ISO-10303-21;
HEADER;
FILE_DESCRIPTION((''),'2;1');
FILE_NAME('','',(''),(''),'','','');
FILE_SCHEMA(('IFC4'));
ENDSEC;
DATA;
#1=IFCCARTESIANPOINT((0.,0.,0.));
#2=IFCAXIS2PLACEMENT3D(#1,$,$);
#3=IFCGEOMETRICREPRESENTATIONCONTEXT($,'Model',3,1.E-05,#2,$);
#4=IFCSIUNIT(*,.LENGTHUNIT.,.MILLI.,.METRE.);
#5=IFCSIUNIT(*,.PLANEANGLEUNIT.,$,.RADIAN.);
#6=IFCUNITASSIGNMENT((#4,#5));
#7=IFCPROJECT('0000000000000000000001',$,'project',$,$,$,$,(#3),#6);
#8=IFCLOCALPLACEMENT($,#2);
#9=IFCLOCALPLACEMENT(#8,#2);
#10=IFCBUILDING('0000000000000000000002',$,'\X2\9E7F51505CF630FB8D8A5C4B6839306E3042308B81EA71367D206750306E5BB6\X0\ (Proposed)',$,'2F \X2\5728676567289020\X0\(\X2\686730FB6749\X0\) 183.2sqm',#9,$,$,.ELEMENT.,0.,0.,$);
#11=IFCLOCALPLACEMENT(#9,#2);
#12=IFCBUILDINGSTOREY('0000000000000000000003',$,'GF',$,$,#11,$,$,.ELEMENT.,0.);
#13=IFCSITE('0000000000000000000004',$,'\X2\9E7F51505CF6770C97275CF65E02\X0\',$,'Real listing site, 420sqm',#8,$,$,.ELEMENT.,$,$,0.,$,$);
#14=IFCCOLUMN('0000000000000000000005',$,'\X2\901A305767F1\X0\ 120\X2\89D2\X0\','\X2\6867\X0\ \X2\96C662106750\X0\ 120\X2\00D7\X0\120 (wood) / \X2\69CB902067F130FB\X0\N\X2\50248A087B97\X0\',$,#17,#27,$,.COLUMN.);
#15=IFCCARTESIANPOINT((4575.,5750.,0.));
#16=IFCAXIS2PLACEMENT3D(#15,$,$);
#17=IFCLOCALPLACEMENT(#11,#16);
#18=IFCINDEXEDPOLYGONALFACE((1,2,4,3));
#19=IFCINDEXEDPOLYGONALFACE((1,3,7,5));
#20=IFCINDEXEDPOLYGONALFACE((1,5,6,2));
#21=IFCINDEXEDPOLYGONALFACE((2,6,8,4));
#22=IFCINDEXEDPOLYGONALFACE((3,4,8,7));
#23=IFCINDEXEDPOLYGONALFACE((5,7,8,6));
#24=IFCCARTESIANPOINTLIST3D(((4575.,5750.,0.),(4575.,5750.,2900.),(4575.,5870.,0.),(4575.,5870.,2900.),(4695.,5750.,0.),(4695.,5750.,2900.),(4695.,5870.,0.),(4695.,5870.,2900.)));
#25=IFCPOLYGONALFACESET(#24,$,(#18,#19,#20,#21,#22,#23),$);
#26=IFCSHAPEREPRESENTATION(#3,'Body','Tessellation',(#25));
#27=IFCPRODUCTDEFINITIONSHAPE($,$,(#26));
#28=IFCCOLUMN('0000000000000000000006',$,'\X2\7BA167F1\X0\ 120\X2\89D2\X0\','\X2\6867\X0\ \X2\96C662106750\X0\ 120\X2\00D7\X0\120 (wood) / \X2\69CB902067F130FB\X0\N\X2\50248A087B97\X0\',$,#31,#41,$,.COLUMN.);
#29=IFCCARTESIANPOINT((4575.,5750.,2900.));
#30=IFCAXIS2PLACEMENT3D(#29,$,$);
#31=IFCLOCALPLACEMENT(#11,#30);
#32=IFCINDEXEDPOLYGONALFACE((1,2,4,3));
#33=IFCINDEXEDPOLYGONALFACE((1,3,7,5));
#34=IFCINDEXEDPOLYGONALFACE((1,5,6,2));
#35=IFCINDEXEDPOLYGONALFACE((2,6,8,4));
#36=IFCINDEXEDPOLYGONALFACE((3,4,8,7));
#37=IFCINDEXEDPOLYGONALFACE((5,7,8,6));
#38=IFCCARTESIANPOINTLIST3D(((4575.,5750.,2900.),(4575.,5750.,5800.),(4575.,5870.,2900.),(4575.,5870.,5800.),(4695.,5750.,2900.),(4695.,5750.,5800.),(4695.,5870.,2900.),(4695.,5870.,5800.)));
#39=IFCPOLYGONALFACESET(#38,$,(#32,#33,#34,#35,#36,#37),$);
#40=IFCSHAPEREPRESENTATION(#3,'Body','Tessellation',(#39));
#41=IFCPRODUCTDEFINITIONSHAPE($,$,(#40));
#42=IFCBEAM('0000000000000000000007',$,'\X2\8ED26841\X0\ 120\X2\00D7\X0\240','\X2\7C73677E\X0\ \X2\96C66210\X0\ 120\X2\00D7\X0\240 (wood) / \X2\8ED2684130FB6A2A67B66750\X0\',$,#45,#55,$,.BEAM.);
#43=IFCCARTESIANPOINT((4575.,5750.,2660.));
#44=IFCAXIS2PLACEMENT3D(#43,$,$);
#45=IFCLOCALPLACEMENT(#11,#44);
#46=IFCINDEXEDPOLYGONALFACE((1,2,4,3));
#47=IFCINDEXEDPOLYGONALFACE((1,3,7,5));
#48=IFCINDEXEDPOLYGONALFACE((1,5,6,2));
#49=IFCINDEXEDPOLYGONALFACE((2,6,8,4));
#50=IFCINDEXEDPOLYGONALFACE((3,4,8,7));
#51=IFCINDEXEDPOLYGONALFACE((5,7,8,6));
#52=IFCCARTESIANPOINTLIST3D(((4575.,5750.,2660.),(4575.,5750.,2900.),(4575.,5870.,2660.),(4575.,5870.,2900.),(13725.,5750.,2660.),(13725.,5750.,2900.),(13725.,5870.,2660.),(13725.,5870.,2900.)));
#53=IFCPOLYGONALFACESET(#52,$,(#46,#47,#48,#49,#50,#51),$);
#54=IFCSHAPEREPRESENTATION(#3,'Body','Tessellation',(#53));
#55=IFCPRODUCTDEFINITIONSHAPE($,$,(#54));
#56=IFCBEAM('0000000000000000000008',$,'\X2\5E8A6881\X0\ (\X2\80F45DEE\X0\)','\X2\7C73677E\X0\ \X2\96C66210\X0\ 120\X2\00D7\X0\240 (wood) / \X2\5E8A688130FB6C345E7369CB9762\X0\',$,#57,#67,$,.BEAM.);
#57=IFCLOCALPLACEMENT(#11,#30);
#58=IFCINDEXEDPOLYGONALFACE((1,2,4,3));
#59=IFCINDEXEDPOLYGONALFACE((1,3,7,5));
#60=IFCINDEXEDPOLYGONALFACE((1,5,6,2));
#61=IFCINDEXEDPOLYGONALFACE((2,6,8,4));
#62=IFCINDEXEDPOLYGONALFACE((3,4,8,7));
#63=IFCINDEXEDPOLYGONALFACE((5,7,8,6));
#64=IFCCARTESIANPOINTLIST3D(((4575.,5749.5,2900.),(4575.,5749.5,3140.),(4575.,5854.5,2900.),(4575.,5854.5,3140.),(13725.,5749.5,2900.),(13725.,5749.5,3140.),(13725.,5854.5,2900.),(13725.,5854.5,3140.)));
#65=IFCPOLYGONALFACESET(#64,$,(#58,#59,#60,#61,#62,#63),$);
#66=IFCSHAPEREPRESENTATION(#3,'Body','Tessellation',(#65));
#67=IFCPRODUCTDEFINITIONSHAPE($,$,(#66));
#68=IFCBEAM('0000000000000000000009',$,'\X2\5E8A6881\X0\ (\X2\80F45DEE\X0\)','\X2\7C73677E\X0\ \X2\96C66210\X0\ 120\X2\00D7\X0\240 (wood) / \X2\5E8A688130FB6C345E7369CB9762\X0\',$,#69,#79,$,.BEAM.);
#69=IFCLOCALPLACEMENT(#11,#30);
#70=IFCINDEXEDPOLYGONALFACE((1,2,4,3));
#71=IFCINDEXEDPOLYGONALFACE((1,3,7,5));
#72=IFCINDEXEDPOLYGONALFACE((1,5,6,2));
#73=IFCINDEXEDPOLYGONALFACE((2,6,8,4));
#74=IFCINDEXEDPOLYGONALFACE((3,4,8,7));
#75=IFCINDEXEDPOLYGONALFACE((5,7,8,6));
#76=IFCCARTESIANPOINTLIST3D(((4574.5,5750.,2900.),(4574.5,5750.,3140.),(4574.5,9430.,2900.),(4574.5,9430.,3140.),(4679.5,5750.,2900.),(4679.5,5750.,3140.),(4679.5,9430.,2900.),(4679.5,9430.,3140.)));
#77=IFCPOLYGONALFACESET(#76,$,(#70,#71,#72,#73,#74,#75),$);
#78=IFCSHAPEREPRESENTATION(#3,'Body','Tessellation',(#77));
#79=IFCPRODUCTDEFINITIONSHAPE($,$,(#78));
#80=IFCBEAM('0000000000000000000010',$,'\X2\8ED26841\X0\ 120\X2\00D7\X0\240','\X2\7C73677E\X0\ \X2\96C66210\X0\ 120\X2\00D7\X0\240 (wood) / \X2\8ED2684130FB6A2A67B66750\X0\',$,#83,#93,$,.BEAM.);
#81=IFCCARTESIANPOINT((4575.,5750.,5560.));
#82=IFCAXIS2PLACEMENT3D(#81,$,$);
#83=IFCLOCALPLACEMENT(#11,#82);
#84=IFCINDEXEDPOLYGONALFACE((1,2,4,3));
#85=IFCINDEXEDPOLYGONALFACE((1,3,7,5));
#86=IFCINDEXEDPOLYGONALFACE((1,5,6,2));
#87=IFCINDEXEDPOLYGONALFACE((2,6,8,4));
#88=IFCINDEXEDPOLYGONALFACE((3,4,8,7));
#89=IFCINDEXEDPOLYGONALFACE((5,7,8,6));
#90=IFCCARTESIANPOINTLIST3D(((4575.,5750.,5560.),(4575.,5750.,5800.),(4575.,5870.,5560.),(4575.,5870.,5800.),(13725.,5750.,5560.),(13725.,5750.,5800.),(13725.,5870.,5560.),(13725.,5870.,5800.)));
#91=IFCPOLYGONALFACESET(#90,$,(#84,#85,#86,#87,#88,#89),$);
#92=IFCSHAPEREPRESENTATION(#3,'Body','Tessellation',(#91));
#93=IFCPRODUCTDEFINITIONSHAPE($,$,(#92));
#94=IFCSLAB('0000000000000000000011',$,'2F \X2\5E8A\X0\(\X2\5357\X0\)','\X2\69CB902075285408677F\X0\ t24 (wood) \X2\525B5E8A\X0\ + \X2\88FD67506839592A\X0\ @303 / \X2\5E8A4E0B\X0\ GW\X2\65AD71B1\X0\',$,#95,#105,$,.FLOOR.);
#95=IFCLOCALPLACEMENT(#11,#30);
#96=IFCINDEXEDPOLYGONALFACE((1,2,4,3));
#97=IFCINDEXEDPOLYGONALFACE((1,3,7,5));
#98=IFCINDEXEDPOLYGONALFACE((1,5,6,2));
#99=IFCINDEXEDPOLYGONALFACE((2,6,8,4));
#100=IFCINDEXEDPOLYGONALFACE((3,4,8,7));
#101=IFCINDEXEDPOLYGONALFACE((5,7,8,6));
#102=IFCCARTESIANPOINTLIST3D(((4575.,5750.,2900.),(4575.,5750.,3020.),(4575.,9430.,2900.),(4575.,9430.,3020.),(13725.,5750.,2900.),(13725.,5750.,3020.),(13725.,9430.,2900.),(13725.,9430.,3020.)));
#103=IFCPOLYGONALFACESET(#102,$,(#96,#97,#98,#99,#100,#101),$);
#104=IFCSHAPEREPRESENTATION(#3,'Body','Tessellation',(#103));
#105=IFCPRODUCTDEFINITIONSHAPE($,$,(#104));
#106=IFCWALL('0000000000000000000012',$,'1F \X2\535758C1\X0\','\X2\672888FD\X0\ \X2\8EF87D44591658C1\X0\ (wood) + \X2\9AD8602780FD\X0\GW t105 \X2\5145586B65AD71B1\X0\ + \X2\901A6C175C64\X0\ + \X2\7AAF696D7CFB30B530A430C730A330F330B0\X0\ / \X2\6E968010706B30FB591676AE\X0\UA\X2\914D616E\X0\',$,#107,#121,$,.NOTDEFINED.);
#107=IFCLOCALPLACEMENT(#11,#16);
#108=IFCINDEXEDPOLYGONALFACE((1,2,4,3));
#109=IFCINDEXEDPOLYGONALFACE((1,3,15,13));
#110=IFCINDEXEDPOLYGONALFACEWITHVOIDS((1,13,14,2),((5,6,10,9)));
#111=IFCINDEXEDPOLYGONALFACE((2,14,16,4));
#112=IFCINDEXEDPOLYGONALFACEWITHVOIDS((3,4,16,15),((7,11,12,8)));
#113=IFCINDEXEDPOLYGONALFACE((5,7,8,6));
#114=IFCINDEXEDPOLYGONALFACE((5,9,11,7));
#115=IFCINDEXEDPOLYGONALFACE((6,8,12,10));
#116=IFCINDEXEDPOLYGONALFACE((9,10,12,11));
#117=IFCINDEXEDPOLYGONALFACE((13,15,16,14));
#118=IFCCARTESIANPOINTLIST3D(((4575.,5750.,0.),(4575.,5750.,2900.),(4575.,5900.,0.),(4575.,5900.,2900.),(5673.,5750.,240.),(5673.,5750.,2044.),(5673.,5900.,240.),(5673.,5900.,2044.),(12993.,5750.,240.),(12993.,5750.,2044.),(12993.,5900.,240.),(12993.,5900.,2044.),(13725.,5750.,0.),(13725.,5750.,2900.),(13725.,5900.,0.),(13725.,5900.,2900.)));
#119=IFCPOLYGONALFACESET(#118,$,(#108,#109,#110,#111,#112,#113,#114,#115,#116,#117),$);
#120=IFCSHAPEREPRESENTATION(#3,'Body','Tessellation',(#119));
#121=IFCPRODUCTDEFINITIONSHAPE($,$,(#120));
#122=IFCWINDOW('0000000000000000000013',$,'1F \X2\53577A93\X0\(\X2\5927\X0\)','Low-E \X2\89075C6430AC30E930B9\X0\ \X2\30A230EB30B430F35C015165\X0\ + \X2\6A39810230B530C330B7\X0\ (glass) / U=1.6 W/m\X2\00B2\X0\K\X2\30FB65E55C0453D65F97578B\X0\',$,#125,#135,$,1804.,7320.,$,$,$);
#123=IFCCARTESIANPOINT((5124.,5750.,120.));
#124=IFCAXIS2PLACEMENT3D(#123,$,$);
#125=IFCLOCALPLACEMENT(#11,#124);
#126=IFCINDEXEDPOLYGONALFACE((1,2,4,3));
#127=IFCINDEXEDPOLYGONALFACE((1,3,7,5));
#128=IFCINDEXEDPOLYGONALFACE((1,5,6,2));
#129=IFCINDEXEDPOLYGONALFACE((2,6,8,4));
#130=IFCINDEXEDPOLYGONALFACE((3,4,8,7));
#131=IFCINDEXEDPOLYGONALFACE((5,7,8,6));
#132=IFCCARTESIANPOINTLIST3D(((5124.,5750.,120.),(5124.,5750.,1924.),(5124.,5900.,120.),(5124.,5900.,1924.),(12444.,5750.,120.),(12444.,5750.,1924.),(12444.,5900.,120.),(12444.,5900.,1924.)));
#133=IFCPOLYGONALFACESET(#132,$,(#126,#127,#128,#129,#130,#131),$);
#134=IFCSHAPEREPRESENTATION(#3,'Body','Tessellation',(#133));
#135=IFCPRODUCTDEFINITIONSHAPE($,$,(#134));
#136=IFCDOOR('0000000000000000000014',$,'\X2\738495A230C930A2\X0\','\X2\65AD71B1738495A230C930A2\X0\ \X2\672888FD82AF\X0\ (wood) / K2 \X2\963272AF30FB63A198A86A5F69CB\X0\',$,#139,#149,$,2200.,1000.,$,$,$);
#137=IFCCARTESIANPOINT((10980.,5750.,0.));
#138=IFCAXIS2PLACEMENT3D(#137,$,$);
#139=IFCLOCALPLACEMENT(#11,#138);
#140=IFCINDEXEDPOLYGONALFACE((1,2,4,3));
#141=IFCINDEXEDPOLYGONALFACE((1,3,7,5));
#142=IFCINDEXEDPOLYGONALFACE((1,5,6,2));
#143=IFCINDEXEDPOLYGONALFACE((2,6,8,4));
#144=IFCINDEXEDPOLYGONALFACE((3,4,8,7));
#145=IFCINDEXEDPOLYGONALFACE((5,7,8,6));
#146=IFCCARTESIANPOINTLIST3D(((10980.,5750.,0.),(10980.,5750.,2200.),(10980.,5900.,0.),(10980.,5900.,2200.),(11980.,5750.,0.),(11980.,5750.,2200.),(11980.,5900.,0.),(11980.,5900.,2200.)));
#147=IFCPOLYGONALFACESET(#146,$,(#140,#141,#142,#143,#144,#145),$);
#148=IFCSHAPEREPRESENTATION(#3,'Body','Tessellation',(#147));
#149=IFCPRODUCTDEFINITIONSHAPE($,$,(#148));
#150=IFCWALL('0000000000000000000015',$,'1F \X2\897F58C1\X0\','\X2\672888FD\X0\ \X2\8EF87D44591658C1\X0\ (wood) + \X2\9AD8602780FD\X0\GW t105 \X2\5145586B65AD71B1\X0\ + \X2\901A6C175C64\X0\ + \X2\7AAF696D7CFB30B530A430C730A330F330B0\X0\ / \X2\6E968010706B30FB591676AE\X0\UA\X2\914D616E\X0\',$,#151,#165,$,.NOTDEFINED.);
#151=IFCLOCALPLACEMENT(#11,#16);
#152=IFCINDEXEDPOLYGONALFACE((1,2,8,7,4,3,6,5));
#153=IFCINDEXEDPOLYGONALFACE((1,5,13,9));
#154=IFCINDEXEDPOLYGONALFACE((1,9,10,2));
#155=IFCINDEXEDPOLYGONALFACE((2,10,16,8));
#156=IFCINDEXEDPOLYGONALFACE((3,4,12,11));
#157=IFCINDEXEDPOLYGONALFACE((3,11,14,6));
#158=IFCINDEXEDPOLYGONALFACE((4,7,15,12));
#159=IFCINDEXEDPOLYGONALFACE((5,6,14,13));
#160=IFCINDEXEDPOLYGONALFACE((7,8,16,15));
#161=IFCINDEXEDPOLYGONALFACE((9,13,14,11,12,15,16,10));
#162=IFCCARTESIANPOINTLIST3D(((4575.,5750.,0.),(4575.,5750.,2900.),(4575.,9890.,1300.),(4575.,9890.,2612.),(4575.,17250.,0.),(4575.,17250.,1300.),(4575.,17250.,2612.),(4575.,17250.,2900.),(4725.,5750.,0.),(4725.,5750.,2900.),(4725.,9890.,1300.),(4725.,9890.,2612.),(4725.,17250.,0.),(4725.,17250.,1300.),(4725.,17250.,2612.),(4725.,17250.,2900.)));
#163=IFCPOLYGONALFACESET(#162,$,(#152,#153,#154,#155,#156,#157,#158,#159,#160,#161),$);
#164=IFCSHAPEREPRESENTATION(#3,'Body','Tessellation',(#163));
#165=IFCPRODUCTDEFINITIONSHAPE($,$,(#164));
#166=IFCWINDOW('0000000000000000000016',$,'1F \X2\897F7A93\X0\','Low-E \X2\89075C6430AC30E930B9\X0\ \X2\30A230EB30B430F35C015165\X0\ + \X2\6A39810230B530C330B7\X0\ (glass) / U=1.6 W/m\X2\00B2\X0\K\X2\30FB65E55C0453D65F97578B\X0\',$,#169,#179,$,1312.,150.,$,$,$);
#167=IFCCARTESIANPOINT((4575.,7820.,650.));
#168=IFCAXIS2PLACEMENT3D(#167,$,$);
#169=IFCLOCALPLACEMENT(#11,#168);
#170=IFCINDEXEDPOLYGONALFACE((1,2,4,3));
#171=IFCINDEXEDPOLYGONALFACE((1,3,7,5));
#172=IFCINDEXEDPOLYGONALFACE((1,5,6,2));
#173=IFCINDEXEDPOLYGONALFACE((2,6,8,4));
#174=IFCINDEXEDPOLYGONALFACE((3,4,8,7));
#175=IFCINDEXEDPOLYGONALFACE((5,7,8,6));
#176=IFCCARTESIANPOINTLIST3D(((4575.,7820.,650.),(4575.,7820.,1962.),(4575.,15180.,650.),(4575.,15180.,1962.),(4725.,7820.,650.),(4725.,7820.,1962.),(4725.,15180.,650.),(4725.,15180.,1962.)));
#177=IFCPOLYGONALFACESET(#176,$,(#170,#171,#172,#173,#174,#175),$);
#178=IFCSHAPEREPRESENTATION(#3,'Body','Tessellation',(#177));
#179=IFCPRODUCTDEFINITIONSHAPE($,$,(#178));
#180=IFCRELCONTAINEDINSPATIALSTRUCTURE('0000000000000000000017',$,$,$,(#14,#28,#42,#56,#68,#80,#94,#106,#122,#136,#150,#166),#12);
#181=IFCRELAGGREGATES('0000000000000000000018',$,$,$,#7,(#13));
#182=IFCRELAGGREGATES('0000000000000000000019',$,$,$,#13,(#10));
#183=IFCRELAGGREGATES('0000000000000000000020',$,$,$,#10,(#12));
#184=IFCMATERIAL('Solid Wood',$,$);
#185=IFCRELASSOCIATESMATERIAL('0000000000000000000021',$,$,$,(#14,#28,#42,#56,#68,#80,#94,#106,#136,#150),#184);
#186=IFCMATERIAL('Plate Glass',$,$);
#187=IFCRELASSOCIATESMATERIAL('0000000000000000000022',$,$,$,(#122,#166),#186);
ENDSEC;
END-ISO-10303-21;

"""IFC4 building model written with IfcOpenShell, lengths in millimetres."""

from ifc_helpers import new_model, si_unit, frame, frame_2d, origin, place, context, project, spatial, rectangle, extrude, material, element, fill, save


model = new_model("IFC4")

# Units and contexts
model_context = context("Model", 3, precision=1e-05, world=origin())
ifc_project = project(units=[si_unit("LENGTHUNIT", "METRE", prefix="MILLI"), si_unit("PLANEANGLEUNIT", "RADIAN")], contexts=[model_context])

# Site, building, storey
site_placement = place(None, origin())
site = spatial("IfcSite", under=ifc_project, at=site_placement, Name="鹿児島県霧島市", ObjectType="Real listing site, 420sqm", CompositionType="ELEMENT", RefElevation=0.0)
building_placement = place(site_placement, origin())
building = spatial("IfcBuilding", under=site, at=building_placement, Name="鹿児島・越屋根のある自然素材の家 (Proposed)", ObjectType="2F 在来木造(桧・杉) 183.2sqm", CompositionType="ELEMENT", ElevationOfRefHeight=0.0, ElevationOfTerrain=0.0)
storey_placement = place(building_placement, origin())
storey = spatial("IfcBuildingStorey", under=building, at=storey_placement, Name="GF", CompositionType="ELEMENT", Elevation=0.0)

# Columns
ifc_material_1 = material(Name="Solid Wood")
column_1_placement = place(storey_placement, frame((4575.0, 5750.0, 0.0)))
element("IfcColumn", 1, at=column_1_placement, inside=storey, material=ifc_material_1, Name="通し柱 120角", Description="桧 集成材 120×120 (wood) / 構造柱・N値計算", PredefinedType="COLUMN", context=model_context, shape_type="SweptSolid", body=[
    extrude(rectangle(XDim=120.0, YDim=120.0, at=frame_2d((60.0, 60.0))), frame((4575.0, 5750.0, 0.0)), (0.0, 0.0, 1.0), 2900.0),
])
column_2_placement = place(storey_placement, frame((4575.0, 5750.0, 2900.0)))
element("IfcColumn", 2, at=column_2_placement, inside=storey, material=ifc_material_1, Name="管柱 120角", Description="桧 集成材 120×120 (wood) / 構造柱・N値計算", PredefinedType="COLUMN", context=model_context, shape_type="SweptSolid", body=[
    extrude(rectangle(XDim=120.0, YDim=120.0, at=frame_2d((60.0, 60.0))), frame((4575.0, 5750.0, 2900.0)), (0.0, 0.0, 1.0), 2900.0),
])

# Beams
beam_1_placement = place(storey_placement, frame((4575.0, 5750.0, 2660.0)))
element("IfcBeam", 3, at=beam_1_placement, inside=storey, material=ifc_material_1, Name="軒桁 120×240", Description="米松 集成 120×240 (wood) / 軒桁・横架材", PredefinedType="BEAM", context=model_context, shape_type="SweptSolid", body=[
    extrude(rectangle(XDim=9150.0, YDim=120.0, at=frame_2d((4575.0, 60.0))), frame((4575.0, 5750.0, 2660.0)), (0.0, 0.0, 1.0), 240.0),
])
beam_2_placement = place(storey_placement, frame((4575.0, 5750.0, 2900.0)))
element("IfcBeam", 4, at=beam_2_placement, inside=storey, material=ifc_material_1, Name="床梁 (胴差)", Description="米松 集成 120×240 (wood) / 床梁・水平構面", PredefinedType="BEAM", context=model_context, shape_type="SweptSolid", body=[
    extrude(rectangle(XDim=9150.0, YDim=105.0, at=frame_2d((4575.0, 52.0))), frame((4575.0, 5750.0, 2900.0)), (0.0, 0.0, 1.0), 240.0),
])
beam_3_placement = place(storey_placement, frame((4575.0, 5750.0, 2900.0)))
element("IfcBeam", 5, at=beam_3_placement, inside=storey, material=ifc_material_1, Name="床梁 (胴差)", Description="米松 集成 120×240 (wood) / 床梁・水平構面", PredefinedType="BEAM", context=model_context, shape_type="SweptSolid", body=[
    extrude(rectangle(XDim=105.0, YDim=3680.0, at=frame_2d((52.0, 1840.0))), frame((4575.0, 5750.0, 2900.0)), (0.0, 0.0, 1.0), 240.0),
])
beam_4_placement = place(storey_placement, frame((4575.0, 5750.0, 5560.0)))
element("IfcBeam", 6, at=beam_4_placement, inside=storey, material=ifc_material_1, Name="軒桁 120×240", Description="米松 集成 120×240 (wood) / 軒桁・横架材", PredefinedType="BEAM", context=model_context, shape_type="SweptSolid", body=[
    extrude(rectangle(XDim=9150.0, YDim=120.0, at=frame_2d((4575.0, 60.0))), frame((4575.0, 5750.0, 5560.0)), (0.0, 0.0, 1.0), 240.0),
])

# Slab
slab_1_placement = place(storey_placement, frame((4575.0, 5750.0, 2900.0)))
element("IfcSlab", 7, at=slab_1_placement, inside=storey, material=ifc_material_1, Name="2F 床(南)", Description="構造用合板 t24 (wood) 剛床 + 製材根太 @303 / 床下 GW断熱", PredefinedType="FLOOR", context=model_context, shape_type="SweptSolid", body=[
    extrude(rectangle(XDim=9150.0, YDim=3680.0, at=frame_2d((4575.0, 1840.0))), frame((4575.0, 5750.0, 2900.0)), (0.0, 0.0, 1.0), 120.0),
])

# Wall, openings, window, door
wall_1_placement = place(storey_placement, frame((4575.0, 5750.0, 0.0)))
wall_1 = element("IfcWall", 8, at=wall_1_placement, inside=storey, material=ifc_material_1, Name="1F 南壁", Description="木製 軸組外壁 (wood) + 高性能GW t105 充填断熱 + 通気層 + 窯業系サイディング / 準耐火・外皮UA配慮", PredefinedType="NOTDEFINED", context=model_context, shape_type="SweptSolid", body=[
    extrude(rectangle(XDim=9150.0, YDim=150.0, at=frame_2d((4575.0, 75.0))), frame((4575.0, 5750.0, 0.0)), (0.0, 0.0, 1.0), 2900.0),
])
opening_1_placement = place(storey_placement, frame((5124.0, 5750.0, 120.0)))
opening_1 = element("IfcOpeningElement", 9, at=opening_1_placement, cuts=wall_1, PredefinedType="NOTDEFINED", context=model_context, shape_type="SweptSolid", body=[
    extrude(rectangle(XDim=7320.0, YDim=150.0, at=frame_2d((3660.0, 75.0))), frame((5124.0, 5750.0, 120.0)), (0.0, 0.0, 1.0), 1804.0),
])
opening_2_placement = place(storey_placement, frame((10980.0, 5750.0, 0.0)))
opening_2 = element("IfcOpeningElement", 10, at=opening_2_placement, cuts=wall_1, PredefinedType="NOTDEFINED", context=model_context, shape_type="SweptSolid", body=[
    extrude(rectangle(XDim=1000.0, YDim=150.0, at=frame_2d((500.0, 75.0))), frame((10980.0, 5750.0, 0.0)), (0.0, 0.0, 1.0), 2200.0),
])
ifc_material_2 = material(Name="Plate Glass")
window_1_placement = place(storey_placement, frame((5124.0, 5750.0, 120.0)))
window_1 = element("IfcWindow", 11, at=window_1_placement, inside=storey, material=ifc_material_2, Name="1F 南窓(大)", Description="Low-E 複層ガラス アルゴン封入 + 樹脂サッシ (glass) / U=1.6 W/m²K・日射取得型", OverallHeight=1804.0, OverallWidth=7320.0, context=model_context, shape_type="SweptSolid", body=[
    extrude(rectangle(XDim=7320.0, YDim=150.0, at=frame_2d((3660.0, 75.0))), frame((5124.0, 5750.0, 120.0)), (0.0, 0.0, 1.0), 1804.0),
])
fill(opening_1, window_1)
door_placement = place(storey_placement, frame((10980.0, 5750.0, 0.0)))
door = element("IfcDoor", 12, at=door_placement, inside=storey, material=ifc_material_1, Name="玄関ドア", Description="断熱玄関ドア 木製芯 (wood) / K2 防犯・採風機構", OverallHeight=2200.0, OverallWidth=1000.0, context=model_context, shape_type="SweptSolid", body=[
    extrude(rectangle(XDim=1000.0, YDim=150.0, at=frame_2d((500.0, 75.0))), frame((10980.0, 5750.0, 0.0)), (0.0, 0.0, 1.0), 2200.0),
])
fill(opening_2, door)

# Wall, opening, window
wall_2_placement = place(storey_placement, frame((4575.0, 5750.0, 0.0)))
wall_2 = element("IfcWall", 13, at=wall_2_placement, inside=storey, material=ifc_material_1, Name="1F 西壁", Description="木製 軸組外壁 (wood) + 高性能GW t105 充填断熱 + 通気層 + 窯業系サイディング / 準耐火・外皮UA配慮", PredefinedType="NOTDEFINED", context=model_context, shape_type="SweptSolid", body=[
    extrude(rectangle(XDim=150.0, YDim=11500.0, at=frame_2d((75.0, 5750.0))), frame((4575.0, 5750.0, 0.0)), (0.0, 0.0, 1.0), 2900.0),
])
opening_3_placement = place(storey_placement, frame((4575.0, 7820.0, 650.0)))
opening_3 = element("IfcOpeningElement", 14, at=opening_3_placement, cuts=wall_2, PredefinedType="NOTDEFINED", context=model_context, shape_type="SweptSolid", body=[
    extrude(rectangle(XDim=150.0, YDim=7360.0, at=frame_2d((75.0, 3680.0))), frame((4575.0, 7820.0, 650.0)), (0.0, 0.0, 1.0), 1312.0),
])
window_2_placement = place(storey_placement, frame((4575.0, 7820.0, 650.0)))
window_2 = element("IfcWindow", 15, at=window_2_placement, inside=storey, material=ifc_material_2, Name="1F 西窓", Description="Low-E 複層ガラス アルゴン封入 + 樹脂サッシ (glass) / U=1.6 W/m²K・日射取得型", OverallHeight=1312.0, OverallWidth=150.0, context=model_context, shape_type="SweptSolid", body=[
    extrude(rectangle(XDim=150.0, YDim=7360.0, at=frame_2d((75.0, 3680.0))), frame((4575.0, 7820.0, 650.0)), (0.0, 0.0, 1.0), 1312.0),
])
fill(opening_3, window_2)

save(model, "model.ifc")
